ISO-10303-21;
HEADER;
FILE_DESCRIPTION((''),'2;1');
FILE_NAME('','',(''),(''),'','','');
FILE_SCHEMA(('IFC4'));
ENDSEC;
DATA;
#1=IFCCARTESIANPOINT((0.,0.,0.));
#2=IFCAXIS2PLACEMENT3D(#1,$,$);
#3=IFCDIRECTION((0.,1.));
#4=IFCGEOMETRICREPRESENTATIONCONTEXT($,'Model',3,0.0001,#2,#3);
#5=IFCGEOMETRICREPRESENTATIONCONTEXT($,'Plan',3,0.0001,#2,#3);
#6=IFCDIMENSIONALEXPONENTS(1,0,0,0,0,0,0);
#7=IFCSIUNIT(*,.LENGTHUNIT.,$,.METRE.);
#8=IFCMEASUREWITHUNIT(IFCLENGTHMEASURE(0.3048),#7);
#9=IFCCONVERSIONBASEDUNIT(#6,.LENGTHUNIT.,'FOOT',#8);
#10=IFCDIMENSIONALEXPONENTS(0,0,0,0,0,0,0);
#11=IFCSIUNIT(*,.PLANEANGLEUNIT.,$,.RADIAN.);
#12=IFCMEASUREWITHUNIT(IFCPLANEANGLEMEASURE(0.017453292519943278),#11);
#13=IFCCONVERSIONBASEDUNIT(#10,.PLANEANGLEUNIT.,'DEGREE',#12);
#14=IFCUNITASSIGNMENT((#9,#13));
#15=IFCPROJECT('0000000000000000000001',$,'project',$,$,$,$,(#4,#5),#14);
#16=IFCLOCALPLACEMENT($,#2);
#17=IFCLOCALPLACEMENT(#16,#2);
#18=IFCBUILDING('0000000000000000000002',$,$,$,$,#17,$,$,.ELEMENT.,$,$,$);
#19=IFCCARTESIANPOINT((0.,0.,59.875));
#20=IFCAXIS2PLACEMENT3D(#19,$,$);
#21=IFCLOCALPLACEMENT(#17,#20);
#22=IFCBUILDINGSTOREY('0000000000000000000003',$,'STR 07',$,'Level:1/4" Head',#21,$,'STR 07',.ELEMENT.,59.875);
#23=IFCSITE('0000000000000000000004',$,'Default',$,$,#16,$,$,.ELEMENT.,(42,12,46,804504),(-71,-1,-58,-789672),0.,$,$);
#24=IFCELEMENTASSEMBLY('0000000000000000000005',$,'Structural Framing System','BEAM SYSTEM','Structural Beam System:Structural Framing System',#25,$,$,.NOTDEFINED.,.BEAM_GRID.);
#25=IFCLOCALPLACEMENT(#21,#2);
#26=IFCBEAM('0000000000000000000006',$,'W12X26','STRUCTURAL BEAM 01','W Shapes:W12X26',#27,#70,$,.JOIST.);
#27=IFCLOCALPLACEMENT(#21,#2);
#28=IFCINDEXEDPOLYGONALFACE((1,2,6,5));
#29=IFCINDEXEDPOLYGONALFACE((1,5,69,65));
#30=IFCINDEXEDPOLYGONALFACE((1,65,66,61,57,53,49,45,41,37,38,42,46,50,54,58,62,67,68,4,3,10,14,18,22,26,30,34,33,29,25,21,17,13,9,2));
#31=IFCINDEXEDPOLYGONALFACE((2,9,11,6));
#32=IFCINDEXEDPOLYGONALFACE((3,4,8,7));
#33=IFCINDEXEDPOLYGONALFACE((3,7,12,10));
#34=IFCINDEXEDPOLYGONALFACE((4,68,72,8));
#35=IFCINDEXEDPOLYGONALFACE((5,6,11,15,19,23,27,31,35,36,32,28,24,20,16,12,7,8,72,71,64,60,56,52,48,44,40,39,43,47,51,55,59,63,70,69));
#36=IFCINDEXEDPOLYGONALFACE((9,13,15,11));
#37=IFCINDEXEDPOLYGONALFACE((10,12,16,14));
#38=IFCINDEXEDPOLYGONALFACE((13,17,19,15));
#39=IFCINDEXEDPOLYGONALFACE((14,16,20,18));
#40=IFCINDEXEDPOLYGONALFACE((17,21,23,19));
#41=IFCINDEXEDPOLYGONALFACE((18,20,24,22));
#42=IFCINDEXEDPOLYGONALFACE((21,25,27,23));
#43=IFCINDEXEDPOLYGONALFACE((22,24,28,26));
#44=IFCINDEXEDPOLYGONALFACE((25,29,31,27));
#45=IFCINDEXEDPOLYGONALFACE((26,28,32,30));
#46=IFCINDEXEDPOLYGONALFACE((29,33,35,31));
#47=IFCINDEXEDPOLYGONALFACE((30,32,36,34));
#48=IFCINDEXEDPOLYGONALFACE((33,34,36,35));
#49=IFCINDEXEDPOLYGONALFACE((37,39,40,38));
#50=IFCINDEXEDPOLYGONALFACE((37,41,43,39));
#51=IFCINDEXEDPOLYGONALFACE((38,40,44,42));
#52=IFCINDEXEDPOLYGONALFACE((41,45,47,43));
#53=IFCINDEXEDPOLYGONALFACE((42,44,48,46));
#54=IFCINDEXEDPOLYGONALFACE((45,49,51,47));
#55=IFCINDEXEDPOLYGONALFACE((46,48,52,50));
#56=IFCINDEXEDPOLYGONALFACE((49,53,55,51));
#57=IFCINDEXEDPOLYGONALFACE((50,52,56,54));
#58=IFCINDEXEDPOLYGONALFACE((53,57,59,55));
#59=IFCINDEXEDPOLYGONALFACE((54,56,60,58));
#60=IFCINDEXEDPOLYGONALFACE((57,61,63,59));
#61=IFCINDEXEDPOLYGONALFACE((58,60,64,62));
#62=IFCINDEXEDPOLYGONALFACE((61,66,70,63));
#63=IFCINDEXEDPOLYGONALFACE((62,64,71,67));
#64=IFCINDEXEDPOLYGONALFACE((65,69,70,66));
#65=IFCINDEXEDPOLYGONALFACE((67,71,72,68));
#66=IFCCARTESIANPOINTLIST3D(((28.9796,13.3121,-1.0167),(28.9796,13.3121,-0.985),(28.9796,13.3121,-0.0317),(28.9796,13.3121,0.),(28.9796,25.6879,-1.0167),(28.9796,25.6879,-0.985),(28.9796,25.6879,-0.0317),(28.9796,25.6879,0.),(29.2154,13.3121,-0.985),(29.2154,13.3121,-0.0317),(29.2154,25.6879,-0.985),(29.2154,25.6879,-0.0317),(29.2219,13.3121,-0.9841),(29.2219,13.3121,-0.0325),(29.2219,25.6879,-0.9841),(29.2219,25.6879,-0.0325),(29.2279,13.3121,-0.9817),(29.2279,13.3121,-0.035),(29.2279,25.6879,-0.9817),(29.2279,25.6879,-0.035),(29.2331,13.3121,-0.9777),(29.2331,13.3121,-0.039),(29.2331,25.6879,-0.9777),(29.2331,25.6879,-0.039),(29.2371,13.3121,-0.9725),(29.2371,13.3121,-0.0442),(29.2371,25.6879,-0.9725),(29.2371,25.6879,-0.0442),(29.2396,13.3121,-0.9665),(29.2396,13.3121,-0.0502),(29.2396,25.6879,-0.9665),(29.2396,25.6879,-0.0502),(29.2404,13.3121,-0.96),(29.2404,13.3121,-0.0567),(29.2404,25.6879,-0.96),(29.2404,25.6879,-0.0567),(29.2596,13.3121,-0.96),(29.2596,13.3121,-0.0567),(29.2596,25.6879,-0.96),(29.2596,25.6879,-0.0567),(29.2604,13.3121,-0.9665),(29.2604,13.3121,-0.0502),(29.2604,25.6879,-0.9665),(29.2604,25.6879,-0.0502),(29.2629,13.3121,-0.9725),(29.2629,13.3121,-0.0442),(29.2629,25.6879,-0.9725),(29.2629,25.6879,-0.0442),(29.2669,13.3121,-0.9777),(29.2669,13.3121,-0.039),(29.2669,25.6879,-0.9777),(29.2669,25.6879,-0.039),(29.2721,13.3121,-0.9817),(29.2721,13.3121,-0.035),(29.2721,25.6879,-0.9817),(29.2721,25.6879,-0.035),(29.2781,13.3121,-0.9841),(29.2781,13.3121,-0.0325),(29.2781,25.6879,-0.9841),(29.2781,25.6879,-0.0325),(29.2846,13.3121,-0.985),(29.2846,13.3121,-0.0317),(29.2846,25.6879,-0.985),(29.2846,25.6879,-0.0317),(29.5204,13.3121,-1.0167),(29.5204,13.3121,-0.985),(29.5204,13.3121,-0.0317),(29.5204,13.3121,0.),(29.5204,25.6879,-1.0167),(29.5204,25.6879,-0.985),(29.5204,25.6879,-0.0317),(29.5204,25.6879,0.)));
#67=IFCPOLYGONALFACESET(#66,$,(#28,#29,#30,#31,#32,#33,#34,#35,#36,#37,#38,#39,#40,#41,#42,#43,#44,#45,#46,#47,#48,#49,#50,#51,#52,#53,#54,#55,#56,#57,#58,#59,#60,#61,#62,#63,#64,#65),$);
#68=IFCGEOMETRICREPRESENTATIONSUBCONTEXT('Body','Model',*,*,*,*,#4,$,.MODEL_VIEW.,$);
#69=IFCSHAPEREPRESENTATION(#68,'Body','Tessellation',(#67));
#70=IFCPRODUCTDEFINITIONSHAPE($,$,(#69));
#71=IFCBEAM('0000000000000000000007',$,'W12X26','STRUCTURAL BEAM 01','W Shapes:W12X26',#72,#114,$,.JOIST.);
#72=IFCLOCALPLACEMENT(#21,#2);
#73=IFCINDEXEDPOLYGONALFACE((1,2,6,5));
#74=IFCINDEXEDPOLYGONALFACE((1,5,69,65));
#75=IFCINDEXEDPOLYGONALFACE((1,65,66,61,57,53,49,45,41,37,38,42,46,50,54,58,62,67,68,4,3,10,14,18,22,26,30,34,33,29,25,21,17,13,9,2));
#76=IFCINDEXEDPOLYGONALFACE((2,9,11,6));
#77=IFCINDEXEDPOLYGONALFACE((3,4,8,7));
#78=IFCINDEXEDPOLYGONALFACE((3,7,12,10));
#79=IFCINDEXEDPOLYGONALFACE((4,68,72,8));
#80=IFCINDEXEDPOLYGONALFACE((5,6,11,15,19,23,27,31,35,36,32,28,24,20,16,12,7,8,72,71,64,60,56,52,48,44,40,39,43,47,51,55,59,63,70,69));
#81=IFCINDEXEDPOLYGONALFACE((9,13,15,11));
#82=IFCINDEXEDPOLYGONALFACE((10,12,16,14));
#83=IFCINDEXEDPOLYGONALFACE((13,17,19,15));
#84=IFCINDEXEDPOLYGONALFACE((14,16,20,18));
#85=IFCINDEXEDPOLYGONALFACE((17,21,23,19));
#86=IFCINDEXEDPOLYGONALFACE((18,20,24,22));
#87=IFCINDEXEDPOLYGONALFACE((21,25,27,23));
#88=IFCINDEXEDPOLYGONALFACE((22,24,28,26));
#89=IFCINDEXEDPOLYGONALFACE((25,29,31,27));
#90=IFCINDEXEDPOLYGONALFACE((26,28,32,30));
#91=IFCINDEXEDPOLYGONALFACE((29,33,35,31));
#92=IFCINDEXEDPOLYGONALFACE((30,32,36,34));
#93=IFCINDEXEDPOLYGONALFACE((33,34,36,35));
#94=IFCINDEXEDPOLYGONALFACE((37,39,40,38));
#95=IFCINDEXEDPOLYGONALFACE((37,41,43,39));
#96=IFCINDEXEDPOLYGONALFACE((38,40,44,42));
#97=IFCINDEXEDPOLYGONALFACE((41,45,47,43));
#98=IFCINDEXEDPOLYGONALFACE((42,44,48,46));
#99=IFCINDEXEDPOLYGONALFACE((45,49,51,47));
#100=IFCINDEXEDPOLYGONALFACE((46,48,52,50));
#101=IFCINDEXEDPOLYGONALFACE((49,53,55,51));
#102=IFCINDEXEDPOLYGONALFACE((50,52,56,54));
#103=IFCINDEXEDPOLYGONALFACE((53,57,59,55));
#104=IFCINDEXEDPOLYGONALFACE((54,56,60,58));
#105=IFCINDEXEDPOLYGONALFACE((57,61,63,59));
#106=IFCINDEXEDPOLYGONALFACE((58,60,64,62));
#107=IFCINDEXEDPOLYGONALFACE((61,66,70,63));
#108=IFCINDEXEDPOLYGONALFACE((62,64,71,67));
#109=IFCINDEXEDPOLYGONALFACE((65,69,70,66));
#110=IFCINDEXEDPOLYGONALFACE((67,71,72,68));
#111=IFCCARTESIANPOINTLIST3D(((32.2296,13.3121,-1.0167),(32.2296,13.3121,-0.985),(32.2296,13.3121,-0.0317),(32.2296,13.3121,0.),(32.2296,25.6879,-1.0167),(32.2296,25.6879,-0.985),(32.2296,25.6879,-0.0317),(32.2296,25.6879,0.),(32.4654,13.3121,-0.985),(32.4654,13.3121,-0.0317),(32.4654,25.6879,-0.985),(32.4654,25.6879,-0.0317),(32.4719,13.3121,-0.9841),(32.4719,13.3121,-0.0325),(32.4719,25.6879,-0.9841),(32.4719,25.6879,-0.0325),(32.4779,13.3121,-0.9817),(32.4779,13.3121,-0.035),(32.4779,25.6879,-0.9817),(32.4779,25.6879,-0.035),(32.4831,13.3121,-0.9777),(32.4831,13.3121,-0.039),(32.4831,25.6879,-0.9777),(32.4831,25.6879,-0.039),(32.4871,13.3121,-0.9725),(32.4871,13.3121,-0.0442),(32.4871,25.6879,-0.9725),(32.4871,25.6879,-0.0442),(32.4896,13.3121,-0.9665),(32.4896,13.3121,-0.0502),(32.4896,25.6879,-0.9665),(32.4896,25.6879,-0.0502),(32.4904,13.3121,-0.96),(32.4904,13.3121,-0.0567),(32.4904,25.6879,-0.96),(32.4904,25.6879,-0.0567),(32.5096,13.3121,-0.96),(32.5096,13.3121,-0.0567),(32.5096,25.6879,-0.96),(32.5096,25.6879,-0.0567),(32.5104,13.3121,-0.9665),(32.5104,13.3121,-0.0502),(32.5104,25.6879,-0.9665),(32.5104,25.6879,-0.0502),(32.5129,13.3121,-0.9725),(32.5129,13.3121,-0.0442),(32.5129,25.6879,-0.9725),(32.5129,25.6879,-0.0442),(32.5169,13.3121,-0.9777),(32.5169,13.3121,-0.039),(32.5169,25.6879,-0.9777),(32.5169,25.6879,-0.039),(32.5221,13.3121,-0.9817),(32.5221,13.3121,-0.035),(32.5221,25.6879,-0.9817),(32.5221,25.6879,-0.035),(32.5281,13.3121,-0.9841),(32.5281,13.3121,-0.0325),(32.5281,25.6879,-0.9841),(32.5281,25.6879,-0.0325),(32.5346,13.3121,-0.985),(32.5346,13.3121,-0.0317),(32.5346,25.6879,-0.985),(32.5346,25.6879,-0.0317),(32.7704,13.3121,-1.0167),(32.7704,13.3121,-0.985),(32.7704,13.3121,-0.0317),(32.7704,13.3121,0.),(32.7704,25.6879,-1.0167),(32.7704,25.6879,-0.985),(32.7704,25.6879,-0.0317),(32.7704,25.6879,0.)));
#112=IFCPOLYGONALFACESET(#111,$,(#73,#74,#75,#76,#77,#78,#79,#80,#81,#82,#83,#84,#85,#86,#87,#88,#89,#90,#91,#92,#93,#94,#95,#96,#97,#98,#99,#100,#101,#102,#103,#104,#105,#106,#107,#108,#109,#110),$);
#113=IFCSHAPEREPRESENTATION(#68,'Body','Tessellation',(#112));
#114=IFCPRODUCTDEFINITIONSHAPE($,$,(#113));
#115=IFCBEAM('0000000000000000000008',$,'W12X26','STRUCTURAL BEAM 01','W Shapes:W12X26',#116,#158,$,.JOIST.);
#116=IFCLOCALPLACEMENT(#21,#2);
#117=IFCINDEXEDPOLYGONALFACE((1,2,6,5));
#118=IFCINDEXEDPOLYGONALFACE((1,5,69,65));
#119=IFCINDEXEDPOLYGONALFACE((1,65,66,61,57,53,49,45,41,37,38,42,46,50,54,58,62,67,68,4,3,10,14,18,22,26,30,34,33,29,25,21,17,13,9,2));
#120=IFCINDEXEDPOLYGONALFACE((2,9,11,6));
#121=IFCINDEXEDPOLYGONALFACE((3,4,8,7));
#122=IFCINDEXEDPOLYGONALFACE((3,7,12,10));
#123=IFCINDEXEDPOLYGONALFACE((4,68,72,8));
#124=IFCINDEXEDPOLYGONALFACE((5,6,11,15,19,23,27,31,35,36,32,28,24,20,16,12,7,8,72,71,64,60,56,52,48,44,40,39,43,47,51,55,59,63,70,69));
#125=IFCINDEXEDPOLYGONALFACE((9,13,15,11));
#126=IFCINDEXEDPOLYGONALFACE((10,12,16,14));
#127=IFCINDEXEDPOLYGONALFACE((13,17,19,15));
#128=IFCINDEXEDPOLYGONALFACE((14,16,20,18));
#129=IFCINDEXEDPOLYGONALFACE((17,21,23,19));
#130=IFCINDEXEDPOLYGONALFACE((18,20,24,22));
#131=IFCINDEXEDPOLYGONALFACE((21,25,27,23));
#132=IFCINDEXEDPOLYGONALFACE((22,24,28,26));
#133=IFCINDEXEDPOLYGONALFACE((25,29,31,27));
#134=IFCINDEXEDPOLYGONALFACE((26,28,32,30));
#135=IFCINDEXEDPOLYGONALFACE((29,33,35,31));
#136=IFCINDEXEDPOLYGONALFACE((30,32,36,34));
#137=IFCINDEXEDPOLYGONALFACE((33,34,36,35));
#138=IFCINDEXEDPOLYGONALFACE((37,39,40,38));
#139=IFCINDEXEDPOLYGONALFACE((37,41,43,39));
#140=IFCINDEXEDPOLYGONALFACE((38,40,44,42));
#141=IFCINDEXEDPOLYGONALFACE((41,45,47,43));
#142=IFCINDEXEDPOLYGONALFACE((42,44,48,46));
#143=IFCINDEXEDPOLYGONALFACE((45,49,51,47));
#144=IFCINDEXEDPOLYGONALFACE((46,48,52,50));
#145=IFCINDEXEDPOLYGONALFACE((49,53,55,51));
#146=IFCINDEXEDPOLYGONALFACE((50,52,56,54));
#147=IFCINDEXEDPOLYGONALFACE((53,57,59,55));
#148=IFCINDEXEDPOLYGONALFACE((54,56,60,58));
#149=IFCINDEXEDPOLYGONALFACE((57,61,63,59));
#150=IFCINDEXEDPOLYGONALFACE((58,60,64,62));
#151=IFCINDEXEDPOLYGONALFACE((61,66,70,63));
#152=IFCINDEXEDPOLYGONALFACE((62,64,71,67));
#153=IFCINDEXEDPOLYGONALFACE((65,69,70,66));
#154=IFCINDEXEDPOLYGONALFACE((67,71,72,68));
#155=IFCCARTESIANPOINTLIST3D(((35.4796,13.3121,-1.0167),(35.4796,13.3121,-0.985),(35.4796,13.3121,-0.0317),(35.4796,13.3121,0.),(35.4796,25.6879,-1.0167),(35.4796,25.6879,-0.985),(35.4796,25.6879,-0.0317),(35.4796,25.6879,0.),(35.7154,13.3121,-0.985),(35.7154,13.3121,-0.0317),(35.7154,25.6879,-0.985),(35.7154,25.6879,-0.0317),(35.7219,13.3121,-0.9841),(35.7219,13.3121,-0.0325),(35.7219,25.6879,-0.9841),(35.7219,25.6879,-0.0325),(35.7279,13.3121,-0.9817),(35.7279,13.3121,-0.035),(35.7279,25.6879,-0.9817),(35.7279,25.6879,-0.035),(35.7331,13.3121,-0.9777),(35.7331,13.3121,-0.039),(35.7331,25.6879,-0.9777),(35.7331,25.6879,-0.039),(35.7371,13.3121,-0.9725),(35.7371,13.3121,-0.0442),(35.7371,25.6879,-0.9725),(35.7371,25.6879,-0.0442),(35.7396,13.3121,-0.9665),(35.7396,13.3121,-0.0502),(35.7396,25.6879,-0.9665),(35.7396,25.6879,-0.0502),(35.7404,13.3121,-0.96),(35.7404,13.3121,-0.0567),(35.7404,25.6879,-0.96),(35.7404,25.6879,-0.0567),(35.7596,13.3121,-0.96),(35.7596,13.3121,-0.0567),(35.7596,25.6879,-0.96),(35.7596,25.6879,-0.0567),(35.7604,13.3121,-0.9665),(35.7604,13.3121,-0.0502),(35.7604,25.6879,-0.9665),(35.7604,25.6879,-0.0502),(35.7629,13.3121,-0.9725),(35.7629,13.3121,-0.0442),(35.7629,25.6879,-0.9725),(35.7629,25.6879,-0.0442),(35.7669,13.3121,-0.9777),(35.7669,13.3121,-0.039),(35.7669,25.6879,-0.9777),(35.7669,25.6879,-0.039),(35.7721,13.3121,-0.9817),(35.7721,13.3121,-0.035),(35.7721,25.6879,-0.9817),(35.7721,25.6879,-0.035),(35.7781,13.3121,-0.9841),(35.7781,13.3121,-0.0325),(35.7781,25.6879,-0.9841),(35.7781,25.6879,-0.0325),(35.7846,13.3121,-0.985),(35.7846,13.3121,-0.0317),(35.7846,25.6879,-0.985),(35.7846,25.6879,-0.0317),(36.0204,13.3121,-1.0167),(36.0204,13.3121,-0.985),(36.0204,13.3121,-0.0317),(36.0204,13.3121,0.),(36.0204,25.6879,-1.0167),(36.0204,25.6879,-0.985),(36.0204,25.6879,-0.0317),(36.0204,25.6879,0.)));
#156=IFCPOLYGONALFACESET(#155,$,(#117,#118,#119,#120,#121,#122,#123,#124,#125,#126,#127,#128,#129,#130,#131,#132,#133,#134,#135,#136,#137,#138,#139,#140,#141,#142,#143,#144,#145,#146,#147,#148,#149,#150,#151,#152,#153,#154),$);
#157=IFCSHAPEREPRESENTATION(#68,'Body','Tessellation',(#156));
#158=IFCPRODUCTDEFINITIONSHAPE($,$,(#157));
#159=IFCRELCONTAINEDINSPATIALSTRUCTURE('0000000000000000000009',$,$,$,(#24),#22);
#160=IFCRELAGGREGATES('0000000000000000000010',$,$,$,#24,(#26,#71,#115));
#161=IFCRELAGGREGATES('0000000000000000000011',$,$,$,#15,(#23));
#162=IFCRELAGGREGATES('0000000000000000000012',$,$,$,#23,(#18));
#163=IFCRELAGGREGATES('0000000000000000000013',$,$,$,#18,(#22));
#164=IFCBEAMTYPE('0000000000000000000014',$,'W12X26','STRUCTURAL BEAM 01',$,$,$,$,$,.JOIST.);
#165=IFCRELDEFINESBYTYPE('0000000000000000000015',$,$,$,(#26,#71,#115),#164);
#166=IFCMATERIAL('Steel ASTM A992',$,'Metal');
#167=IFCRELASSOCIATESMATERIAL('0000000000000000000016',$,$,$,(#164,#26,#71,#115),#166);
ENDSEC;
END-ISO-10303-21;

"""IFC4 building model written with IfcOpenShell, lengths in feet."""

from ifc_helpers import new_model, entity, si_unit, converted_unit, direction, frame, origin, place, context, subcontext, project, spatial, line, arc, indexed_curve, outline, extrude, source, transform, mapped, material, type_object, type_shapes, element, aggregate, save


model = new_model("IFC4")

# Units and contexts
model_context = context("Model", 3, precision=0.0001, world=origin(), true_north=direction((0.0, 1.0)))
plan_context = context("Plan", 3, precision=0.0001, world=origin(), true_north=direction((0.0, 1.0)))
body_context = subcontext(model_context, "Body", "Model", "MODEL_VIEW")
ifc_project = project(units=[converted_unit("LENGTHUNIT", "FOOT", entity("IfcLengthMeasure", 0.3048), si_unit("LENGTHUNIT", "METRE"), dimensions=[1, 0, 0, 0, 0, 0, 0]), converted_unit("PLANEANGLEUNIT", "DEGREE", entity("IfcPlaneAngleMeasure", 0.017453292519943278), si_unit("PLANEANGLEUNIT", "RADIAN"), dimensions=[0, 0, 0, 0, 0, 0, 0])], contexts=[model_context, plan_context])

# Site, building, storey
site_placement = place(None, origin())
site = spatial("IfcSite", under=ifc_project, at=site_placement, Name="Default", CompositionType="ELEMENT", RefLatitude=(42, 12, 46, 804504), RefLongitude=(-71, -1, -58, -789672), RefElevation=0.0)
building_placement = place(site_placement, origin())
building = spatial("IfcBuilding", under=site, at=building_placement, CompositionType="ELEMENT")
storey_placement = place(building_placement, frame((0.0, 0.0, 59.875)))
storey = spatial("IfcBuildingStorey", under=building, at=storey_placement, Name="STR 07", ObjectType="Level:1/4\" Head", LongName="STR 07", CompositionType="ELEMENT", Elevation=59.875)

# Element assembly, beams
ifc_material = material(Name="Steel ASTM A992", Category="Metal")
beam_type_1 = type_object("IfcBeamType", Name="W12X26", Description="STRUCTURAL BEAM 01", PredefinedType="JOIST", material=ifc_material)
shared_shape = source(origin(), body_context, "Body", "SweptSolid", [
    extrude(outline(indexed_curve([(-0.2704, -0.4767), (-0.2704, -0.5083), (0.2704, -0.5083), (0.2704, -0.4767), (0.0346, -0.4767), (0.0169, -0.4693), (0.0096, -0.4517), (0.0096, 0.4517), (0.0169, 0.4693), (0.0346, 0.4767), (0.2704, 0.4767), (0.2704, 0.5083), (-0.2704, 0.5083), (-0.2704, 0.4767), (-0.0346, 0.4767), (-0.0169, 0.4693), (-0.0096, 0.4517), (-0.0096, -0.4517), (-0.0169, -0.4693), (-0.0346, -0.4767)], segments=[line(1, 2, 3, 4, 5), arc(5, 6, 7), line(7, 8), arc(8, 9, 10), line(10, 11, 12, 13, 14, 15), arc(15, 16, 17), line(17, 18), arc(18, 19, 20), line(20, 1)], self_intersect=False)), frame((-6.1879, 0.0, 0.0), z_axis=(-1.0, 0.0, 0.0), x_axis=(0.0, -1.0, 0.0)), (0.0, 0.0, -1.0), 12.3758),
])
type_shapes(beam_type_1, [shared_shape])
assembly_1_placement = place(storey_placement, origin())
assembly_1 = element("IfcElementAssembly", 1, at=assembly_1_placement, inside=storey, Name="Structural Framing System", Description="BEAM SYSTEM", ObjectType="Structural Beam System:Structural Framing System", AssemblyPlace="NOTDEFINED", PredefinedType="BEAM_GRID")
beam_1_placement = place(assembly_1_placement, frame((29.25, 19.5, -0.5083), z_axis=(0.0, 0.0, 1.0), x_axis=(0.0, 1.0, 0.0)))
beam_1 = element("IfcBeam", 2, at=beam_1_placement, type_object=beam_type_1, material=ifc_material, Name="W12X26", Description="STRUCTURAL BEAM 01", ObjectType="W Shapes:W12X26", PredefinedType="JOIST", context=body_context, shape_type="MappedRepresentation", body=[
    mapped(shared_shape, transform((0.0, 0.0, 0.0), scale=1.0)),
])
beam_2_placement = place(assembly_1_placement, frame((32.5, 19.5, -0.5083), z_axis=(0.0, 0.0, 1.0), x_axis=(0.0, 1.0, 0.0)))
beam_2 = element("IfcBeam", 3, at=beam_2_placement, type_object=beam_type_1, material=ifc_material, Name="W12X26", Description="STRUCTURAL BEAM 01", ObjectType="W Shapes:W12X26", PredefinedType="JOIST", context=body_context, shape_type="MappedRepresentation", body=[
    mapped(shared_shape, transform((0.0, 0.0, 0.0), scale=1.0)),
])
beam_3_placement = place(assembly_1_placement, frame((35.75, 19.5, -0.5083), z_axis=(0.0, 0.0, 1.0), x_axis=(0.0, 1.0, 0.0)))
beam_3 = element("IfcBeam", 4, at=beam_3_placement, type_object=beam_type_1, material=ifc_material, Name="W12X26", Description="STRUCTURAL BEAM 01", ObjectType="W Shapes:W12X26", PredefinedType="JOIST", context=body_context, shape_type="MappedRepresentation", body=[
    mapped(shared_shape, transform((0.0, 0.0, 0.0), scale=1.0)),
])
aggregate(assembly_1, [beam_1, beam_2, beam_3])

save(model, "model.ifc")
